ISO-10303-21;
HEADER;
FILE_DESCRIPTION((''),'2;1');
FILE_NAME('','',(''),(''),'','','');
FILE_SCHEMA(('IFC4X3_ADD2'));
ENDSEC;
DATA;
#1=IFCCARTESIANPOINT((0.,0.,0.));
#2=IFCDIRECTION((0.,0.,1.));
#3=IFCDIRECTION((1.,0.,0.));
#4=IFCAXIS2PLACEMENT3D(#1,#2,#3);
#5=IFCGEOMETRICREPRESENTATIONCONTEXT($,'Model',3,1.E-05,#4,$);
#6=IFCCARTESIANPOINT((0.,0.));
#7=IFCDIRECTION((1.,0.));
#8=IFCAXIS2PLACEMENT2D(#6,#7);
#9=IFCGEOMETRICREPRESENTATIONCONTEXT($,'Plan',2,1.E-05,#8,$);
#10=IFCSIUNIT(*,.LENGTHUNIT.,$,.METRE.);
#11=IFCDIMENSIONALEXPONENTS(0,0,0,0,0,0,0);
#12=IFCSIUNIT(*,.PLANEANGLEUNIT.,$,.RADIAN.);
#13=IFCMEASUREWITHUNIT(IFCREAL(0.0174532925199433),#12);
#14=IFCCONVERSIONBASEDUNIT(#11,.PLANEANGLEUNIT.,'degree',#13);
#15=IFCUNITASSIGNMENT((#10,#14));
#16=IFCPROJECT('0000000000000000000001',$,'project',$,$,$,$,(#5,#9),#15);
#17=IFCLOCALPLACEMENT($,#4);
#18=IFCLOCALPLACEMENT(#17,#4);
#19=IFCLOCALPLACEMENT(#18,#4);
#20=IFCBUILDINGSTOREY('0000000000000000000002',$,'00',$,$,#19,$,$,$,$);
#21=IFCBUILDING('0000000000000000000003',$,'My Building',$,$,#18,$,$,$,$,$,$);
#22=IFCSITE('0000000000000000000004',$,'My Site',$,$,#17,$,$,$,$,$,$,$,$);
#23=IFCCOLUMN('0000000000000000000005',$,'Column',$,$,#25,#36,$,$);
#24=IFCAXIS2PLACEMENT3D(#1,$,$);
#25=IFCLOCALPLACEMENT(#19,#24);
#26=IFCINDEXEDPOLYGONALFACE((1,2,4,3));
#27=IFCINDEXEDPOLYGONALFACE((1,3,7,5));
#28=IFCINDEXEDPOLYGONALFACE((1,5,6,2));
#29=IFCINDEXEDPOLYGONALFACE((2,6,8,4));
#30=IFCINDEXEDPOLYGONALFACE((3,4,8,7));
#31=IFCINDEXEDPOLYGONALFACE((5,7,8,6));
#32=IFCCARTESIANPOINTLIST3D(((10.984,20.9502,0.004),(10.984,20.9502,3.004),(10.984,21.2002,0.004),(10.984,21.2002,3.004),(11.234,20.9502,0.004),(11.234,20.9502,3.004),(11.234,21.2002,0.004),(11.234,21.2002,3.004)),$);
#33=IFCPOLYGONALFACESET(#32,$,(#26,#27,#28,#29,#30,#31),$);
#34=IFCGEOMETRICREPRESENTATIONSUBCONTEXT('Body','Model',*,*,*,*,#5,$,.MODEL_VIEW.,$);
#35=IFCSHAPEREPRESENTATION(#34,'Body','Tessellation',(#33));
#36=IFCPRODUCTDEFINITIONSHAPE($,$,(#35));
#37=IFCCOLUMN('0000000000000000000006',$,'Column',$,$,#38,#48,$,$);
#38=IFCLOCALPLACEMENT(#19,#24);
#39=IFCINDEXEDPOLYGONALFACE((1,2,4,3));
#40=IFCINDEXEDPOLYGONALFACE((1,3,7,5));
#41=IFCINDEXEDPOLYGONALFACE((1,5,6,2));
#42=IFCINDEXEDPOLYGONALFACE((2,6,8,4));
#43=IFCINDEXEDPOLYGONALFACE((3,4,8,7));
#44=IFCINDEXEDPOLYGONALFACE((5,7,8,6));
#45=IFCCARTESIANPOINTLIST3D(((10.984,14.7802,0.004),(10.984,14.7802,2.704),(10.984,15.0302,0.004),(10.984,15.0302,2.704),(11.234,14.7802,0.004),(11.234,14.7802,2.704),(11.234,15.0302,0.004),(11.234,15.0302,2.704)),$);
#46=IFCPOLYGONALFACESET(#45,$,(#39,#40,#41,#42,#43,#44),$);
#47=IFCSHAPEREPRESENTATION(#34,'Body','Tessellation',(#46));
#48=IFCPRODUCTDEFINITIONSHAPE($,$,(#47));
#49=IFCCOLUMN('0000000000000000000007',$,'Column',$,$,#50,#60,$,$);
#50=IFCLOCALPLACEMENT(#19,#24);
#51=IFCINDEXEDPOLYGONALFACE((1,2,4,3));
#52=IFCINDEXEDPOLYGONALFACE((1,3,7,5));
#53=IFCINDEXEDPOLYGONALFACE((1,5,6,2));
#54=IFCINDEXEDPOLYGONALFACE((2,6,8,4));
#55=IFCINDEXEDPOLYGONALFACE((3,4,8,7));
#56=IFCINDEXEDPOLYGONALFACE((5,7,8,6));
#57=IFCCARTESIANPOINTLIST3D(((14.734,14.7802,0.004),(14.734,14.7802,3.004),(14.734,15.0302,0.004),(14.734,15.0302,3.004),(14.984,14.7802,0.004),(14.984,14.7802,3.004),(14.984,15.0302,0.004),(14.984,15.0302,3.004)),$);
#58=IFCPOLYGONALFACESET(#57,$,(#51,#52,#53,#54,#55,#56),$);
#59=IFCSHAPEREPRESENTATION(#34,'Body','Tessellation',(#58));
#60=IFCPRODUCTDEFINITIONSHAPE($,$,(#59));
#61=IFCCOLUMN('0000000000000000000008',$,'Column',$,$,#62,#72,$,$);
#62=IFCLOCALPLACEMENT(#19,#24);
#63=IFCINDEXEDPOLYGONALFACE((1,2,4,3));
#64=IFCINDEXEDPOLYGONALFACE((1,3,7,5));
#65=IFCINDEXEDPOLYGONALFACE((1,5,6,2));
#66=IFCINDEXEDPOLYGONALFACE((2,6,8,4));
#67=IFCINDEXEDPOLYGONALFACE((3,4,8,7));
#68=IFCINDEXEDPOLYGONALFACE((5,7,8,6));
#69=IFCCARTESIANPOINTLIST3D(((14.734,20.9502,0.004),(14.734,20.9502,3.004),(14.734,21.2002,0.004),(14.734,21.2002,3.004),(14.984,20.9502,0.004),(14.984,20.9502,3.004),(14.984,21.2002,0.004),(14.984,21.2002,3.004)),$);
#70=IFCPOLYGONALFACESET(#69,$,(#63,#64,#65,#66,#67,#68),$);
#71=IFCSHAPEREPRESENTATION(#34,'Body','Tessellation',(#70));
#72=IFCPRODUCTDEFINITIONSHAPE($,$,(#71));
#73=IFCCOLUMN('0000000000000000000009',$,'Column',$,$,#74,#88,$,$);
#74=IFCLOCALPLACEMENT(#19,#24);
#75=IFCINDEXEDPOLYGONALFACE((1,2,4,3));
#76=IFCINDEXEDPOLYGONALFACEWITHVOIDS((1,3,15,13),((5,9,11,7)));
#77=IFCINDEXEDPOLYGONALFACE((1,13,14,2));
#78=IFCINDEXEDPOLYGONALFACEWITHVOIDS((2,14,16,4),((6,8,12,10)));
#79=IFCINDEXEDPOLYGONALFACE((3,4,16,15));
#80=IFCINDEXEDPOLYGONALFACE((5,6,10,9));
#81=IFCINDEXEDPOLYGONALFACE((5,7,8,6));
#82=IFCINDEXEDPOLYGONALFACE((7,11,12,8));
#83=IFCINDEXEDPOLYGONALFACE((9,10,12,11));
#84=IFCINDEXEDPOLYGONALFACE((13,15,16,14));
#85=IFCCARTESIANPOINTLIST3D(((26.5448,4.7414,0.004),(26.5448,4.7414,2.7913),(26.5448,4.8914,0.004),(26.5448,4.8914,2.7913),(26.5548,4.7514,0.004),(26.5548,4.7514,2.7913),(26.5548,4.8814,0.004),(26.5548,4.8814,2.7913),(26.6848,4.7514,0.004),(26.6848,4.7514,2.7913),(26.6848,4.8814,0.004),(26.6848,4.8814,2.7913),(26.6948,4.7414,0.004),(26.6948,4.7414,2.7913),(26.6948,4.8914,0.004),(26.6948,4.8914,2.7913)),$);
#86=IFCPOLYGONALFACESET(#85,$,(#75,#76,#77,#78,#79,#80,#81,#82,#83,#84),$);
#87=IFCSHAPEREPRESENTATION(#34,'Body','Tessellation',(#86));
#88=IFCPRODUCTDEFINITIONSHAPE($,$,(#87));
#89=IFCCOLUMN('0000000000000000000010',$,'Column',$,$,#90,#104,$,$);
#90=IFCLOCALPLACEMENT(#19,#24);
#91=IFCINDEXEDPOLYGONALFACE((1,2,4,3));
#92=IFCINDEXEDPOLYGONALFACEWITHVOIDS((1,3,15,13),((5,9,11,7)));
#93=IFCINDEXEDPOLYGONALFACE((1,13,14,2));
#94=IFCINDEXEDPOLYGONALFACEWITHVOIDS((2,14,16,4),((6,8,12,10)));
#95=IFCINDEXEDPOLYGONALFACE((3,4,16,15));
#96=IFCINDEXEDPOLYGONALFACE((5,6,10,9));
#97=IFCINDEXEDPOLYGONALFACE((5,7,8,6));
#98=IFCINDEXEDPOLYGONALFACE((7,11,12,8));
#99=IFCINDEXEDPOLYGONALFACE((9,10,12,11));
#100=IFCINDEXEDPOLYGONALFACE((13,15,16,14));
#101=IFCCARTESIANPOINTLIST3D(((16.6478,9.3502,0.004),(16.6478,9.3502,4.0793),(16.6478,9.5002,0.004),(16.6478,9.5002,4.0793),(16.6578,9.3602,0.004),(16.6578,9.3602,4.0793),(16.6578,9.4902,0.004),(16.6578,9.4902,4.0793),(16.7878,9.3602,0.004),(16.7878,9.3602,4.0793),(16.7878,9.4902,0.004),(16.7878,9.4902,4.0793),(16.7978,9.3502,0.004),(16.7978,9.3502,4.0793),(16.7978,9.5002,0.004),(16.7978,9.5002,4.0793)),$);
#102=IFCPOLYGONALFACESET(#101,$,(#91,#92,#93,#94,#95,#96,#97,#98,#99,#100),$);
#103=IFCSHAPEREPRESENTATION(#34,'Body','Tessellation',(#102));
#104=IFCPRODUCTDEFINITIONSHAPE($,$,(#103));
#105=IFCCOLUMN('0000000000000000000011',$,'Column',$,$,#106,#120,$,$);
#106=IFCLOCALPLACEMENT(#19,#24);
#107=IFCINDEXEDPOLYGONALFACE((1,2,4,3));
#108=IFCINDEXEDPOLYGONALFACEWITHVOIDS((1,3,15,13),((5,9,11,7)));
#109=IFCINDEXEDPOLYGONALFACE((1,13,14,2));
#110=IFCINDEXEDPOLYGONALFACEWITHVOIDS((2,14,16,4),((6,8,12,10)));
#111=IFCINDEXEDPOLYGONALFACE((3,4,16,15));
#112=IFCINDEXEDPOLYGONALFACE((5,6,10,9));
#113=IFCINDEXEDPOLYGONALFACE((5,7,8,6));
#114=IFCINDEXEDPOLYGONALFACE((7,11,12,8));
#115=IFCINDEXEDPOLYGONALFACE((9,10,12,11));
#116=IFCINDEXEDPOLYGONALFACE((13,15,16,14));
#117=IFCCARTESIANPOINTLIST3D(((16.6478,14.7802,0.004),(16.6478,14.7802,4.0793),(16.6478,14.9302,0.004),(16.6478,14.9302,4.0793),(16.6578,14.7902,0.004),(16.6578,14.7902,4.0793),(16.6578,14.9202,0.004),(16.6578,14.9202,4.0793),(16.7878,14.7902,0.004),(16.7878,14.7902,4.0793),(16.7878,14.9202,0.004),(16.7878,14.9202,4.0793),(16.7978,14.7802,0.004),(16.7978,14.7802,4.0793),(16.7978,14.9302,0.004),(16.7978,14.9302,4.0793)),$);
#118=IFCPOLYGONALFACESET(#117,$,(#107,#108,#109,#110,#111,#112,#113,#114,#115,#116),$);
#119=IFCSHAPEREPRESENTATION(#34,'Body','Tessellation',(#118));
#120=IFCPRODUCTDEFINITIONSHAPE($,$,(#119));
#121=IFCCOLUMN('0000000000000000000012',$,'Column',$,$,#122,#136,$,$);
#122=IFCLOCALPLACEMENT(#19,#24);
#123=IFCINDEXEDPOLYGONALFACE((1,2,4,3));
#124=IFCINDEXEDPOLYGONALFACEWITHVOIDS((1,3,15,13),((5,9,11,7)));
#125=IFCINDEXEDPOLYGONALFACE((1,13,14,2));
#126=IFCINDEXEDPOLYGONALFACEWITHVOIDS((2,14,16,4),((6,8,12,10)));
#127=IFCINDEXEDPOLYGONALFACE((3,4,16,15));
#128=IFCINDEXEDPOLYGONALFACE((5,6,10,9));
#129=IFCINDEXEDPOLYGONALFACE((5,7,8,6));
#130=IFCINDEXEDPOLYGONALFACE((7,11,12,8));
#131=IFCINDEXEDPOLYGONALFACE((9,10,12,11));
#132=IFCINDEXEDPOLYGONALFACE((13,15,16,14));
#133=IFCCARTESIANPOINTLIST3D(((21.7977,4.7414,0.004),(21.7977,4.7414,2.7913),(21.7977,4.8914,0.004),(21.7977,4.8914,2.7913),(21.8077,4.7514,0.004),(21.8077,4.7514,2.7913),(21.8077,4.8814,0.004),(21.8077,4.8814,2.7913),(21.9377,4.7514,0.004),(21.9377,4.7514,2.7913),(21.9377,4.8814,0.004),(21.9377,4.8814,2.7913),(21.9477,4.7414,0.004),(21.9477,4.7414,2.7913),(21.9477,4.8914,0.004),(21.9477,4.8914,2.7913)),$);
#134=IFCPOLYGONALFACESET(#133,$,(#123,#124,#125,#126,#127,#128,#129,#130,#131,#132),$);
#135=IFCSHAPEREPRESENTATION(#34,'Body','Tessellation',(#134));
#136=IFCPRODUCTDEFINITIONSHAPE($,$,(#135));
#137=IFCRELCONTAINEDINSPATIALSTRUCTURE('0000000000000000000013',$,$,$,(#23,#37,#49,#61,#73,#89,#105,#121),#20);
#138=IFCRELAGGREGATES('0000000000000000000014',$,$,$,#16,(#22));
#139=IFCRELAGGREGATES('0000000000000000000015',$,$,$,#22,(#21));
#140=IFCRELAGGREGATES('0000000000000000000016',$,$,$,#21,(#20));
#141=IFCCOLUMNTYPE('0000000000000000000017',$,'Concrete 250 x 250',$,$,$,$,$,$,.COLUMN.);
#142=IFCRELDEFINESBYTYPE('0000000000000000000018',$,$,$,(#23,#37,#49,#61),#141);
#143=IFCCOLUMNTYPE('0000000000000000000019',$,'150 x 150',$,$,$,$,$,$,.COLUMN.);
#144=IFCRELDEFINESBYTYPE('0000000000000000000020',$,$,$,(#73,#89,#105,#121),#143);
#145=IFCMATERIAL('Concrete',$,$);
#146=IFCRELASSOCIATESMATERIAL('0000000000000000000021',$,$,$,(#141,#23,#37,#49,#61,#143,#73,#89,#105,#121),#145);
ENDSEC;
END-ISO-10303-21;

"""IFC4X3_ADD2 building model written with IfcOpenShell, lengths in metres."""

from ifc_helpers import new_model, entity, si_unit, converted_unit, frame, origin_with_axes, origin_2d_with_axis, place, context, subcontext, project, spatial, rectangle, hollow_rectangle, extrude, material, material_profile, profile_set, profile_usage, type_object, element, save


model = new_model("IFC4X3_ADD2")

# Units and contexts
model_context = context("Model", 3, precision=1e-05, world=origin_with_axes())
plan_context = context("Plan", 2, precision=1e-05, world=origin_2d_with_axis())
body_context = subcontext(model_context, "Body", "Model", "MODEL_VIEW")
ifc_project = project(units=[si_unit("LENGTHUNIT", "METRE"), converted_unit("PLANEANGLEUNIT", "degree", entity("IfcReal", 0.0174532925199433), si_unit("PLANEANGLEUNIT", "RADIAN"), dimensions=[0, 0, 0, 0, 0, 0, 0])], contexts=[model_context, plan_context])

# Site, building, storey
site_placement = place(None, origin_with_axes())
site = spatial("IfcSite", under=ifc_project, at=site_placement, Name="My Site")
building_placement = place(site_placement, origin_with_axes())
building = spatial("IfcBuilding", under=site, at=building_placement, Name="My Building")
storey_placement = place(building_placement, origin_with_axes())
storey = spatial("IfcBuildingStorey", under=building, at=storey_placement, Name="00")

# Columns
ifc_material_1 = material(Name="Concrete")
ifc_material_profile_1 = material_profile(ifc_material_1, rectangle(XDim=0.25, YDim=0.25))
ifc_profile_set_1 = profile_set([ifc_material_profile_1])
ifc_profile_usage_1 = profile_usage(ifc_profile_set_1, cardinal=5)
column_type_1 = type_object("IfcColumnType", Name="Concrete 250 x 250", PredefinedType="COLUMN", material=ifc_profile_set_1)
column_1_placement = place(storey_placement, frame((11.109, 21.0752, 0.004), z_axis=(0.0, 0.0, 1.0), x_axis=(1.0, 0.0, 0.0)))
element("IfcColumn", 1, at=column_1_placement, inside=storey, type_object=column_type_1, material=ifc_profile_usage_1, Name="Column", context=body_context, shape_type="SweptSolid", body=[
    extrude(rectangle(XDim=0.25, YDim=0.25), origin_with_axes(), (0.0, 0.0, 1.0), 3.0),
])
ifc_profile_usage_2 = profile_usage(ifc_profile_set_1, cardinal=5)
column_2_placement = place(storey_placement, frame((11.109, 14.9052, 0.004), z_axis=(0.0, 0.0, 1.0), x_axis=(1.0, 0.0, 0.0)))
element("IfcColumn", 2, at=column_2_placement, inside=storey, type_object=column_type_1, material=ifc_profile_usage_2, Name="Column", context=body_context, shape_type="SweptSolid", body=[
    extrude(rectangle(XDim=0.25, YDim=0.25), origin_with_axes(), (0.0, 0.0, 1.0), 2.7),
])
ifc_profile_usage_3 = profile_usage(ifc_profile_set_1, cardinal=5)
column_3_placement = place(storey_placement, frame((14.859, 14.9052, 0.004), z_axis=(0.0, 0.0, 1.0), x_axis=(1.0, 0.0, 0.0)))
element("IfcColumn", 3, at=column_3_placement, inside=storey, type_object=column_type_1, material=ifc_profile_usage_3, Name="Column", context=body_context, shape_type="SweptSolid", body=[
    extrude(rectangle(XDim=0.25, YDim=0.25), origin_with_axes(), (0.0, 0.0, 1.0), 3.0),
])
ifc_profile_usage_4 = profile_usage(ifc_profile_set_1, cardinal=5)
column_4_placement = place(storey_placement, frame((14.859, 21.0752, 0.004), z_axis=(0.0, 0.0, 1.0), x_axis=(1.0, 0.0, 0.0)))
element("IfcColumn", 4, at=column_4_placement, inside=storey, type_object=column_type_1, material=ifc_profile_usage_4, Name="Column", context=body_context, shape_type="SweptSolid", body=[
    extrude(rectangle(XDim=0.25, YDim=0.25), origin_with_axes(), (0.0, 0.0, 1.0), 3.0),
])
ifc_material_profile_2 = material_profile(ifc_material_1, hollow_rectangle(XDim=0.15, YDim=0.15, WallThickness=0.01))
ifc_profile_set_2 = profile_set([ifc_material_profile_2])
ifc_profile_usage_5 = profile_usage(ifc_profile_set_2, cardinal=5)
column_type_2 = type_object("IfcColumnType", Name="150 x 150", PredefinedType="COLUMN", material=ifc_profile_set_2)
column_5_placement = place(storey_placement, frame((26.6198, 4.8164, 0.004), z_axis=(0.0, 0.0, 1.0), x_axis=(1.0, 0.0, 0.0)))
element("IfcColumn", 5, at=column_5_placement, inside=storey, type_object=column_type_2, material=ifc_profile_usage_5, Name="Column", context=body_context, shape_type="SweptSolid", body=[
    extrude(hollow_rectangle(XDim=0.15, YDim=0.15, WallThickness=0.01), origin_with_axes(), (0.0, 0.0, 1.0), 2.7873),
])
ifc_profile_usage_6 = profile_usage(ifc_profile_set_2, cardinal=5)
column_6_placement = place(storey_placement, frame((16.7228, 9.4252, 0.004), z_axis=(0.0, 0.0, 1.0), x_axis=(1.0, 0.0, 0.0)))
element("IfcColumn", 6, at=column_6_placement, inside=storey, type_object=column_type_2, material=ifc_profile_usage_6, Name="Column", context=body_context, shape_type="SweptSolid", body=[
    extrude(hollow_rectangle(XDim=0.15, YDim=0.15, WallThickness=0.01), origin_with_axes(), (0.0, 0.0, 1.0), 4.0753),
])
ifc_profile_usage_7 = profile_usage(ifc_profile_set_2, cardinal=5)
column_7_placement = place(storey_placement, frame((16.7228, 14.8552, 0.004), z_axis=(0.0, 0.0, 1.0), x_axis=(1.0, 0.0, 0.0)))
element("IfcColumn", 7, at=column_7_placement, inside=storey, type_object=column_type_2, material=ifc_profile_usage_7, Name="Column", context=body_context, shape_type="SweptSolid", body=[
    extrude(hollow_rectangle(XDim=0.15, YDim=0.15, WallThickness=0.01), origin_with_axes(), (0.0, 0.0, 1.0), 4.0753),
])
ifc_profile_usage_8 = profile_usage(ifc_profile_set_2, cardinal=5)
column_8_placement = place(storey_placement, frame((21.8727, 4.8164, 0.004), z_axis=(0.0, 0.0, 1.0), x_axis=(1.0, 0.0, 0.0)))
element("IfcColumn", 8, at=column_8_placement, inside=storey, type_object=column_type_2, material=ifc_profile_usage_8, Name="Column", context=body_context, shape_type="SweptSolid", body=[
    extrude(hollow_rectangle(XDim=0.15, YDim=0.15, WallThickness=0.01), origin_with_axes(), (0.0, 0.0, 1.0), 2.7873),
])

save(model, "model.ifc")
